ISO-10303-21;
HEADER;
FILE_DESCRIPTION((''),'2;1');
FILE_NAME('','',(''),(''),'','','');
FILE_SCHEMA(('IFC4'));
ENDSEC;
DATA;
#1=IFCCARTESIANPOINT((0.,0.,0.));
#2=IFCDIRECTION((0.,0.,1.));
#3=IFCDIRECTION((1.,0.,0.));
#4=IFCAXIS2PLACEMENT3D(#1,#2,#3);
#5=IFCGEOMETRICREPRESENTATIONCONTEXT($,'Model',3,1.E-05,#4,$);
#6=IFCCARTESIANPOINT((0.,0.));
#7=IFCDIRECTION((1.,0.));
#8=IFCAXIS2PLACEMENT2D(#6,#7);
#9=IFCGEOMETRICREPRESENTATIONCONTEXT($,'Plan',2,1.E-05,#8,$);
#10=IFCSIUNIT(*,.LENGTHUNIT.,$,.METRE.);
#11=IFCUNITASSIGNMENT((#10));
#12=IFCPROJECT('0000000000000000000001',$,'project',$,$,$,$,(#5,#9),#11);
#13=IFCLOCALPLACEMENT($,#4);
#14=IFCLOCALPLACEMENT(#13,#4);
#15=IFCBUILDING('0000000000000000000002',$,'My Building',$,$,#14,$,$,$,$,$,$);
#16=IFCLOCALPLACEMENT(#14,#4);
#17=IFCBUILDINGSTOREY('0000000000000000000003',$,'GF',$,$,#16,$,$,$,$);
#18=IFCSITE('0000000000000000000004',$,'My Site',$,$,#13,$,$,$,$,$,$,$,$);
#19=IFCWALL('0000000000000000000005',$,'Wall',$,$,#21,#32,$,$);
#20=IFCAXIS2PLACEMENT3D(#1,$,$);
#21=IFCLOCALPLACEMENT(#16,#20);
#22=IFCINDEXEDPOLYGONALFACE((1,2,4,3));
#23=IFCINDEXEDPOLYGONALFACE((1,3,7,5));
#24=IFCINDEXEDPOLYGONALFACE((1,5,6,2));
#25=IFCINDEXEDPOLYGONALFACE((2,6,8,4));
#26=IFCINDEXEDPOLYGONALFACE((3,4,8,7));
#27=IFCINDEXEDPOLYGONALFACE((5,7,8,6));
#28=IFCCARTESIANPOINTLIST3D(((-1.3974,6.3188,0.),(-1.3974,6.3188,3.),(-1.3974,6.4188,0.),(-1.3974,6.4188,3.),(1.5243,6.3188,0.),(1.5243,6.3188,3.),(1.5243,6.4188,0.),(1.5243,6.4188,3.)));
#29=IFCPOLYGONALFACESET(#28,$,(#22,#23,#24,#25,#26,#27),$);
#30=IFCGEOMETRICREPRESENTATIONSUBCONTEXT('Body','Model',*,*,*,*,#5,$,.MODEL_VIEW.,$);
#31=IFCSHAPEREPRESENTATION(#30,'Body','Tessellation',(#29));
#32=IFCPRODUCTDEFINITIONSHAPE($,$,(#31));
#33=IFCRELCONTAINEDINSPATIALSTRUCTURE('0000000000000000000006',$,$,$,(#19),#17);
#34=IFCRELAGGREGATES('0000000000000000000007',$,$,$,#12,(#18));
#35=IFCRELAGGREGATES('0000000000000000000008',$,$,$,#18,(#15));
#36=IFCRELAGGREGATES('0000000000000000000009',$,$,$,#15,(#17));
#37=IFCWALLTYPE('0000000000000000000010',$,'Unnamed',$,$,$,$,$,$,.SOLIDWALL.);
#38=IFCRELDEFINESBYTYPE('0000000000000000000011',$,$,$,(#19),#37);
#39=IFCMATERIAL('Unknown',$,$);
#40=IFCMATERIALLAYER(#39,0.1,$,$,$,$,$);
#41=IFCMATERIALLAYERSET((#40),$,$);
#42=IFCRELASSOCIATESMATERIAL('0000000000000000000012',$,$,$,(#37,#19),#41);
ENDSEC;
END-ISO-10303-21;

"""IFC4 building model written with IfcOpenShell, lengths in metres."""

from ifc_helpers import new_model, si_unit, frame, origin_with_axes, origin_2d_with_axis, place, context, subcontext, project, spatial, line, indexed_curve, outline, extrude, material, layer, layer_set, layer_usage, type_object, element, save


model = new_model("IFC4")

# Units and contexts
model_context = context("Model", 3, precision=1e-05, world=origin_with_axes())
plan_context = context("Plan", 2, precision=1e-05, world=origin_2d_with_axis())
body_context_1 = subcontext(model_context, "Body", "Model", "MODEL_VIEW")
ifc_project = project(units=[si_unit("LENGTHUNIT", "METRE")], contexts=[model_context, plan_context])

# Site, building, storey
site_placement = place(None, origin_with_axes())
site = spatial("IfcSite", under=ifc_project, at=site_placement, Name="My Site")
building_placement = place(site_placement, origin_with_axes())
building = spatial("IfcBuilding", under=site, at=building_placement, Name="My Building")
storey_placement = place(building_placement, origin_with_axes())
storey = spatial("IfcBuildingStorey", under=building, at=storey_placement, Name="GF")

# Shared definitions
ifc_material = material(Name="Unknown")

# Shared definitions
ifc_layer_1 = layer(ifc_material, 0.1)
ifc_layer_set_1 = layer_set([ifc_layer_1])
wall_type = type_object("IfcWallType", Name="Unnamed", PredefinedType="SOLIDWALL", material=ifc_layer_set_1)

# Wall
ifc_layer_usage_1 = layer_usage(ifc_layer_set_1, "AXIS2", "POSITIVE", 0.0)
wall_1_placement = place(storey_placement, frame((-1.3974, 6.3188, 0.0), z_axis=(0.0, 0.0, 1.0), x_axis=(1.0, 0.000019, 0.0)))
element("IfcWall", 1, at=wall_1_placement, inside=storey, type_object=wall_type, material=ifc_layer_usage_1, Name="Wall", context=body_context_1, shape_type="SweptSolid", body=[
    extrude(outline(indexed_curve([(0.0, 0.0), (0.0, 0.1), (2.9217, 0.1), (2.9217, 0.0)], segments=[line(1, 2, 3, 4, 1)])), origin_with_axes(), (0.0, 0.0, 1.0), 3.0),
])

save(model, "model.ifc")
